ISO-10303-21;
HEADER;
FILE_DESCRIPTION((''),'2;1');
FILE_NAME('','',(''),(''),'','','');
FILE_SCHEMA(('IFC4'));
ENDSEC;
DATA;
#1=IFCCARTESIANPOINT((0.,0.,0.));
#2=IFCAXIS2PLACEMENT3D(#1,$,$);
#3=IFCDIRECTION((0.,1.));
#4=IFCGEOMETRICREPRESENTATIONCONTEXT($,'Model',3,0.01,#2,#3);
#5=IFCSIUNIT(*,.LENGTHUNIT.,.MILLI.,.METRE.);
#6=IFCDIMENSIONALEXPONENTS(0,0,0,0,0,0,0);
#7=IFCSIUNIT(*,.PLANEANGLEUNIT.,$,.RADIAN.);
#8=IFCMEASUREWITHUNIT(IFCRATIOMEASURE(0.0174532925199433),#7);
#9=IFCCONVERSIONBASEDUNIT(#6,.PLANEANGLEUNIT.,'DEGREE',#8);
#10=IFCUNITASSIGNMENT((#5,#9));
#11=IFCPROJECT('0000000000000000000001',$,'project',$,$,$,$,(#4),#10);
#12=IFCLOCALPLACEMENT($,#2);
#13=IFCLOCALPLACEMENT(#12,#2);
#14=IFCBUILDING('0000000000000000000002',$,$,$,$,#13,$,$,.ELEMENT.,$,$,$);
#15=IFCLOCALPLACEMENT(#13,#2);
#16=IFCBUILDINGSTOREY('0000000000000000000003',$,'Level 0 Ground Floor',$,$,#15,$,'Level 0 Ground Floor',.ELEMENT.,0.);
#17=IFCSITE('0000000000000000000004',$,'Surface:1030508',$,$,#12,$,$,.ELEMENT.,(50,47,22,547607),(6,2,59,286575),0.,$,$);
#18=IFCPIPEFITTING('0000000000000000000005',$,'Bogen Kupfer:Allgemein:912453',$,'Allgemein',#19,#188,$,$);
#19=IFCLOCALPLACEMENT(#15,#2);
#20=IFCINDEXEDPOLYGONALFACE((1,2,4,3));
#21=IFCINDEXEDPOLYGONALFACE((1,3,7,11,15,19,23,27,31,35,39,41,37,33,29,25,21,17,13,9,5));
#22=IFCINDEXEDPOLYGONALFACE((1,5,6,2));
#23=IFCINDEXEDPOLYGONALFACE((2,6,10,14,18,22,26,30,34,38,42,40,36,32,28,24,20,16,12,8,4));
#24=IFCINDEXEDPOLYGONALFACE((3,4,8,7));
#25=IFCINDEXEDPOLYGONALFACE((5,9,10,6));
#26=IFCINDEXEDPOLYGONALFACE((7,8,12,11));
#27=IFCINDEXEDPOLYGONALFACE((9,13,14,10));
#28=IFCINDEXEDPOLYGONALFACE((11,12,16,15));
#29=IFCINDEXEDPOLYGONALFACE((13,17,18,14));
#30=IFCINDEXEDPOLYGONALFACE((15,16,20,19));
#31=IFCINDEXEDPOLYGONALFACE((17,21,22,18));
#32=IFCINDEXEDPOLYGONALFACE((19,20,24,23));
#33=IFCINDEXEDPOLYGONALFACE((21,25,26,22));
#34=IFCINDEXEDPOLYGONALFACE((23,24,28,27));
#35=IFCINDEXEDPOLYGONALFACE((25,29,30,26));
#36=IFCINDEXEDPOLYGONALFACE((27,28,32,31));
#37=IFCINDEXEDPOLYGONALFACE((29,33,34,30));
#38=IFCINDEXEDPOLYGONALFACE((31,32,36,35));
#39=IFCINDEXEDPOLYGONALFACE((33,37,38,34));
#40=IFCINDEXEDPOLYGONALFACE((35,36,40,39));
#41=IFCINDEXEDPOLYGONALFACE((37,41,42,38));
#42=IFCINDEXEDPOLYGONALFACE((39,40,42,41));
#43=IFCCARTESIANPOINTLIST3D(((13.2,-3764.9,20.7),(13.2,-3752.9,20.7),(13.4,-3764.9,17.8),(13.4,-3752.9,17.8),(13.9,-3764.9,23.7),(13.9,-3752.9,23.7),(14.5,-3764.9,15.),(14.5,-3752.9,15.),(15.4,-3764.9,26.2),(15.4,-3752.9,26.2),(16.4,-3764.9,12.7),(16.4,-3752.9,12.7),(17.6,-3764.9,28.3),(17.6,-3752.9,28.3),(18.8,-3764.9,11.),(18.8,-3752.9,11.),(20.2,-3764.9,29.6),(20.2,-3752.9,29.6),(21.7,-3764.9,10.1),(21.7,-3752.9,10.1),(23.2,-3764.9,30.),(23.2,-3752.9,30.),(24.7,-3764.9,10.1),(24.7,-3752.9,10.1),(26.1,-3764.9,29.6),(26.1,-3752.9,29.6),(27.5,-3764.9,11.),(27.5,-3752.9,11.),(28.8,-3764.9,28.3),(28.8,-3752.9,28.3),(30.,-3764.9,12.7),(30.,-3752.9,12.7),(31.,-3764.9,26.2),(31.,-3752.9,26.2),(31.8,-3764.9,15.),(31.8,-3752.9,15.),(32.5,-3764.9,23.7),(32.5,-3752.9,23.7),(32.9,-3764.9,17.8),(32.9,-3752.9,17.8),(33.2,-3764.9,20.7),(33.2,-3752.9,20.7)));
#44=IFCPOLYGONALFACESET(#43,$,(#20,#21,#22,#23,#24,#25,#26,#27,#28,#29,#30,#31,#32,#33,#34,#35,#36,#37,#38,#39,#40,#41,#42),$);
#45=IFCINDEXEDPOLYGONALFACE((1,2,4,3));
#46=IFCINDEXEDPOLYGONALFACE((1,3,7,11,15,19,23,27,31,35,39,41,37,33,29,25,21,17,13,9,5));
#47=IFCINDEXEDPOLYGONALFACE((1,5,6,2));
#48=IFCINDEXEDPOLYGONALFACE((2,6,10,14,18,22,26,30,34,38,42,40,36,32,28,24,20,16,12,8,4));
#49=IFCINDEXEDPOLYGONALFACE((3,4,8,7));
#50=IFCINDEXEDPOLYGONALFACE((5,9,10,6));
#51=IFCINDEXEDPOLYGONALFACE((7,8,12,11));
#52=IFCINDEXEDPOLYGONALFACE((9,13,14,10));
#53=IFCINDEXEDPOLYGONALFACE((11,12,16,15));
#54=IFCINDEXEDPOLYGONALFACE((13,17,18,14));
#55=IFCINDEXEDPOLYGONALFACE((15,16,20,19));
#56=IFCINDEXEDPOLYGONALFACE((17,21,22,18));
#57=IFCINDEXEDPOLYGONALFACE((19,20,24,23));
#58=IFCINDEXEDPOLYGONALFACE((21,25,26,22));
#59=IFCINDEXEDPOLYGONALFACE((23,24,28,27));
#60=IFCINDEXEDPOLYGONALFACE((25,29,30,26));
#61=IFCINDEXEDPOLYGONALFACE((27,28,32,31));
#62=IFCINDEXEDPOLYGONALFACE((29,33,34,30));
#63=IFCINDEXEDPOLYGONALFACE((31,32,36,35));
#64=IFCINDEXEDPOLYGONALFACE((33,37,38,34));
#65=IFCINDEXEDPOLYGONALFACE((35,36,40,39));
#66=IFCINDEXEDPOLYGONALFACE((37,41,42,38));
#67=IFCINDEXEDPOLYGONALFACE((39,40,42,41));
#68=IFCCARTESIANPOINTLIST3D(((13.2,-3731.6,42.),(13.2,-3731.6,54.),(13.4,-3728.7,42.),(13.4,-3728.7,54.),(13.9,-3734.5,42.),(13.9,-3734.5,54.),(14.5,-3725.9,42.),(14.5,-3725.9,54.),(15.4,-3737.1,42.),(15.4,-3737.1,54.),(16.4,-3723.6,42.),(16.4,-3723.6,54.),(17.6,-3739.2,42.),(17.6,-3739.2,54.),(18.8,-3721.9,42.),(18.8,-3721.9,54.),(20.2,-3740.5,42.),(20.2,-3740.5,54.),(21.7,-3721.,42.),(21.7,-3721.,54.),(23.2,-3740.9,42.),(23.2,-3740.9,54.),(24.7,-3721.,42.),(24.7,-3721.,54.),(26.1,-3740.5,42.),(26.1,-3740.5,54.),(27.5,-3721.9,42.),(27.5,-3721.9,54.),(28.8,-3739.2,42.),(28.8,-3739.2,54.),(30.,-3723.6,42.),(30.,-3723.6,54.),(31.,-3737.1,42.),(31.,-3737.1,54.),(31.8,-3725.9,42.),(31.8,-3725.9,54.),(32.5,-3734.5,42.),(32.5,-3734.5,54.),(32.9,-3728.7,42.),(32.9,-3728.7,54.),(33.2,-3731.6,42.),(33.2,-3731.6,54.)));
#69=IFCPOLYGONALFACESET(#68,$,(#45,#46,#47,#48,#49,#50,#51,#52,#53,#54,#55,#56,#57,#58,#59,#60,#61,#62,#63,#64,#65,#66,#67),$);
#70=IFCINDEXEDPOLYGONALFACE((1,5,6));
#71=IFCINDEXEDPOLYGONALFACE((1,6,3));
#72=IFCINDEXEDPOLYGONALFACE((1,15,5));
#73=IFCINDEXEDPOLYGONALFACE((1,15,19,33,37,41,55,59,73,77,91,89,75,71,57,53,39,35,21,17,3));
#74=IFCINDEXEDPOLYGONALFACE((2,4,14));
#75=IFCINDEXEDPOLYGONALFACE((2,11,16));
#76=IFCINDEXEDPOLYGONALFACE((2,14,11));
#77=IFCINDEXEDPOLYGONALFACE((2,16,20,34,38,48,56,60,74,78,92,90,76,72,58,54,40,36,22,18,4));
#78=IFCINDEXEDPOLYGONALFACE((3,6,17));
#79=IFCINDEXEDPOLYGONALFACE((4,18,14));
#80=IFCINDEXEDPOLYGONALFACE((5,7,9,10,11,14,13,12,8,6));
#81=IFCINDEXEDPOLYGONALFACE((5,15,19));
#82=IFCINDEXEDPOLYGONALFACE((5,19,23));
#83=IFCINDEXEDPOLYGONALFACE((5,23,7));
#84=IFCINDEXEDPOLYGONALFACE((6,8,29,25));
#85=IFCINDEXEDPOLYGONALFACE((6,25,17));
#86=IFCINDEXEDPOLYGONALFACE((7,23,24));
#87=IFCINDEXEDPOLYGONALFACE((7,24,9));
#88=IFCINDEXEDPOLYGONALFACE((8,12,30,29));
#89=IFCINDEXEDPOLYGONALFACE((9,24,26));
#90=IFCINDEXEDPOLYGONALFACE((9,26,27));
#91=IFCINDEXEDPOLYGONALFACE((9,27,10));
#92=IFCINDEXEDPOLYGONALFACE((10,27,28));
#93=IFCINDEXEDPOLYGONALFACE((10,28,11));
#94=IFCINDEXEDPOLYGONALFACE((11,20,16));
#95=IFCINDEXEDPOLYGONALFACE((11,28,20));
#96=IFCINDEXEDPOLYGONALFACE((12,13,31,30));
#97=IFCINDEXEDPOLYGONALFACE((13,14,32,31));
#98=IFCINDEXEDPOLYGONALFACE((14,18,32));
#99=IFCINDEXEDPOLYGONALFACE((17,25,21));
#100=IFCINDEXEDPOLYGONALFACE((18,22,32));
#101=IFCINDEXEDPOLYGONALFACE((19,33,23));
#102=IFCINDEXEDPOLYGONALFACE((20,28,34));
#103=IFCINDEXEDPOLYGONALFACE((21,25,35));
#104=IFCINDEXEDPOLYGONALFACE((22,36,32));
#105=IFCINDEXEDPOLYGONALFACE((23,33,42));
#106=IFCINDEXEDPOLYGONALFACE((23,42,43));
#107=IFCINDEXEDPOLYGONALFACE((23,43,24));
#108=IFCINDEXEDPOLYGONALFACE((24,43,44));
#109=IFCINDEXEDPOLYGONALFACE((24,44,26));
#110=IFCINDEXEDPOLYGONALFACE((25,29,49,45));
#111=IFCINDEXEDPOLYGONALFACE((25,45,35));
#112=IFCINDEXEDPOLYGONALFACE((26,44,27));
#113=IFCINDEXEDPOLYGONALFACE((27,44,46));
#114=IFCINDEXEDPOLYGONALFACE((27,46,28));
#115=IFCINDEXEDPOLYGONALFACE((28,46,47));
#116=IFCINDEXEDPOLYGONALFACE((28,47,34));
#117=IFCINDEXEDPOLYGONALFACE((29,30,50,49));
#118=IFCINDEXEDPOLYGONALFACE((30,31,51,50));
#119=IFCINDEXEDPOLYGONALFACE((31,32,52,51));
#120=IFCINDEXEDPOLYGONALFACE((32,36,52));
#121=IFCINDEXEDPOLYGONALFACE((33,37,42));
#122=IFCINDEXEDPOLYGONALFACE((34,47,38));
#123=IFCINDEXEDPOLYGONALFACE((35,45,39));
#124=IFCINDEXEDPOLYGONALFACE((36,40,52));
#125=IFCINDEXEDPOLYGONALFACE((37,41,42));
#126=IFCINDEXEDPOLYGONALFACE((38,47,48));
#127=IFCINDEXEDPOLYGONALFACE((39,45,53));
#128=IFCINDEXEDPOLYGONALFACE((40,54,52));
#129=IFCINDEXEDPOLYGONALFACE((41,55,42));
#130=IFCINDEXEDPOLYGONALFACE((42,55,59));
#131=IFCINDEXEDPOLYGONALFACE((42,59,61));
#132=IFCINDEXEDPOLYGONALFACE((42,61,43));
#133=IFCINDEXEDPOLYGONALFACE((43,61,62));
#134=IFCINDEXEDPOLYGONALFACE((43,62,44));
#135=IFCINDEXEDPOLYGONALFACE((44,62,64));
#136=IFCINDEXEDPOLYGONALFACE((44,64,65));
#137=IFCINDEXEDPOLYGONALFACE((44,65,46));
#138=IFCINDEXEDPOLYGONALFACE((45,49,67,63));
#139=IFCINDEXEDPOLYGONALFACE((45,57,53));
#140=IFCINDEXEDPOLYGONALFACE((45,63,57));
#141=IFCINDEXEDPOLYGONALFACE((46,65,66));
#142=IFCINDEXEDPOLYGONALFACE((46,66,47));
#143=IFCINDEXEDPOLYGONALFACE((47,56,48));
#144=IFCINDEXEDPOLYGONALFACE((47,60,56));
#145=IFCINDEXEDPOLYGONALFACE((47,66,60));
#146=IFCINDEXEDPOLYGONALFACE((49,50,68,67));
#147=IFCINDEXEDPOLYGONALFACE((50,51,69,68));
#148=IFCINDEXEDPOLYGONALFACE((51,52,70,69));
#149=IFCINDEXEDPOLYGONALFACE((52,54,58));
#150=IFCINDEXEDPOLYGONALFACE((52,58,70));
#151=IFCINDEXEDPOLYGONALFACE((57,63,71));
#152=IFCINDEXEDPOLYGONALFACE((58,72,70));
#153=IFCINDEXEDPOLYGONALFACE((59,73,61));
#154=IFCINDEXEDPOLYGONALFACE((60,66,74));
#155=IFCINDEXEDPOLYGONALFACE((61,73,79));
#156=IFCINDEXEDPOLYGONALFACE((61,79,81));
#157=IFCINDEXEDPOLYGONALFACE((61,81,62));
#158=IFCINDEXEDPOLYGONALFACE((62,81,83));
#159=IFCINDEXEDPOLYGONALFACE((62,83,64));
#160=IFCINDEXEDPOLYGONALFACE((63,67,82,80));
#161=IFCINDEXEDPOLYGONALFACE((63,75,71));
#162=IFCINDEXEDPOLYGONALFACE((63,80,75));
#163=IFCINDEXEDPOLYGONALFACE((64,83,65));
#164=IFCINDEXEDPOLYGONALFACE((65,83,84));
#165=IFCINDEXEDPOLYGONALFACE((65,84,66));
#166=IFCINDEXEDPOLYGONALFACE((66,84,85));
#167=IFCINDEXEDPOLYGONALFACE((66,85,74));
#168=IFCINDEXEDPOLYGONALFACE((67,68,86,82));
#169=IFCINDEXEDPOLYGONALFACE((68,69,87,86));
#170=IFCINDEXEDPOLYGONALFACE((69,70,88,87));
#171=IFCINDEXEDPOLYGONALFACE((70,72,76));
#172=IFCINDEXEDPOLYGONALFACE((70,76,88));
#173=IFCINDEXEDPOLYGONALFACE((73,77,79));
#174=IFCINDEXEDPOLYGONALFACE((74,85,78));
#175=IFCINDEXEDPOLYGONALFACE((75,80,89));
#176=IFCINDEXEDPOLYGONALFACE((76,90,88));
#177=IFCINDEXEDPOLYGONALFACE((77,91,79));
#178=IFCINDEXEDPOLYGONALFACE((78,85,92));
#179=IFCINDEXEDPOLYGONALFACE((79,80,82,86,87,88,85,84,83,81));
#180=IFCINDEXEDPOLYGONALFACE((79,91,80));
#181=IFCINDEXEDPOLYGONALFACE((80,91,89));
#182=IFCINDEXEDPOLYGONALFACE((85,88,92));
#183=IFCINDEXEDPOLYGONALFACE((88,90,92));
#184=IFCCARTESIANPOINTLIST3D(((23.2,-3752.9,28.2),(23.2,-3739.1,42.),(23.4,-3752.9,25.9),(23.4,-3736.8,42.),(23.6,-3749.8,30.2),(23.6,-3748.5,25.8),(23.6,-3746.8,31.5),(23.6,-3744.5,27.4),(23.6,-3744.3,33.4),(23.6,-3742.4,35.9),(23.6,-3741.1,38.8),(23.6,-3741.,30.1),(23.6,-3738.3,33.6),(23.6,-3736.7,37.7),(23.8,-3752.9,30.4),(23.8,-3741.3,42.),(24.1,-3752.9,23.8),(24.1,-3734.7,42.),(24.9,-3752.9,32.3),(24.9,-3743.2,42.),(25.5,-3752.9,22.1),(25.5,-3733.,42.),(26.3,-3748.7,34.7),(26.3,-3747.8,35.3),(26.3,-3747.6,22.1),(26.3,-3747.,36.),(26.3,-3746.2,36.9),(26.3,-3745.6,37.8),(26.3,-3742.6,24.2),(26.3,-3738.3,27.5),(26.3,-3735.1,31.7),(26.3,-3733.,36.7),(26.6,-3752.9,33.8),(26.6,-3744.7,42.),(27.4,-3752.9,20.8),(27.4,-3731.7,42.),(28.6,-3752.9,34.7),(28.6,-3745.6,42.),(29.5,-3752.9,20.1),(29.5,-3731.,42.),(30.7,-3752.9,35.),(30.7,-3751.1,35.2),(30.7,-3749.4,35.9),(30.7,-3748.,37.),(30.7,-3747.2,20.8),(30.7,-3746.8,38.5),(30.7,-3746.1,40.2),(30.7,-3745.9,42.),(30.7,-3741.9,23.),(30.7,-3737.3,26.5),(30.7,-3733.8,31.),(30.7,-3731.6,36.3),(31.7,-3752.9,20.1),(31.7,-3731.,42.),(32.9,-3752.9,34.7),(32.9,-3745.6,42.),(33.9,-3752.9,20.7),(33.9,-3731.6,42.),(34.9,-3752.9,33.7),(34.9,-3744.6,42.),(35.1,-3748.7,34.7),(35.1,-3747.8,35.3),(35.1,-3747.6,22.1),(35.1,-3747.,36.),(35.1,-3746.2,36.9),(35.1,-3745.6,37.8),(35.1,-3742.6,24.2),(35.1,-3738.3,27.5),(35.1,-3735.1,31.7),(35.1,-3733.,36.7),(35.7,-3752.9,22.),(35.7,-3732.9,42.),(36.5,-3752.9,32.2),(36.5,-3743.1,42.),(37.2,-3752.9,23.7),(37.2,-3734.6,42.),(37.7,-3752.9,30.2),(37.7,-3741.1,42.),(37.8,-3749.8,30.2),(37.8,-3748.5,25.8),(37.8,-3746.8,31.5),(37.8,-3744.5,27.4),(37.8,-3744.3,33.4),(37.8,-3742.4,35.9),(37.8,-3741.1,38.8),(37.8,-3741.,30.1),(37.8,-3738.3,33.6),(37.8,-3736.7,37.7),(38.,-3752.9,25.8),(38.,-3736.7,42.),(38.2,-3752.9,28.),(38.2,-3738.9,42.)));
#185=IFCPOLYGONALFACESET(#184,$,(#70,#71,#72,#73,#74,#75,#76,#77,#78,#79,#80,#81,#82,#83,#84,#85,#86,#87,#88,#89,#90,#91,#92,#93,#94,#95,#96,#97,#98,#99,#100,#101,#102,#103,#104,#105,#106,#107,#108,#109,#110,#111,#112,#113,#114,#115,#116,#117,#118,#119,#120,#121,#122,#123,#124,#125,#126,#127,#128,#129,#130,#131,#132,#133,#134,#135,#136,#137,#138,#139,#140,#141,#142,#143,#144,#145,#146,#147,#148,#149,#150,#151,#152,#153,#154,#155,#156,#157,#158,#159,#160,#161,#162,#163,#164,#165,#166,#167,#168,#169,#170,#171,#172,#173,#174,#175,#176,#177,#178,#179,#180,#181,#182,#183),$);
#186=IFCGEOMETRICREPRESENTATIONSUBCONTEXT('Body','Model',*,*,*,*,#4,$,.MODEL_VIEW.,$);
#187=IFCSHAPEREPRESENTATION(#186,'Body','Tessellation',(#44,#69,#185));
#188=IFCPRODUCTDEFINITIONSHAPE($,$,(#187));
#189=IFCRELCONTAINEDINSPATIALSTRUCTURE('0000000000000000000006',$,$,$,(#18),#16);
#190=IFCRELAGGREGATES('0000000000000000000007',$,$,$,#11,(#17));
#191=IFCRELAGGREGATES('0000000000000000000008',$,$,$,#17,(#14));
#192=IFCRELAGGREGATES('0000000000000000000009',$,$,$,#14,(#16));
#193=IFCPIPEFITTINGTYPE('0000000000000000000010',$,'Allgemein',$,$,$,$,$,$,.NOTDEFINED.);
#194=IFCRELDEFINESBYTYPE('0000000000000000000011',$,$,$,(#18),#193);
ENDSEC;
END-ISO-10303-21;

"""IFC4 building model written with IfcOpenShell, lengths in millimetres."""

from ifc_helpers import new_model, entity, si_unit, converted_unit, direction, frame, frame_2d, origin, place, context, subcontext, project, spatial, circle, extrude, source, transform, mapped, type_object, type_shapes, element, save


model = new_model("IFC4")

# Units and contexts
model_context = context("Model", 3, precision=0.01, world=origin(), true_north=direction((0.0, 1.0)))
body_context = subcontext(model_context, "Body", "Model", "MODEL_VIEW")
ifc_project = project(units=[si_unit("LENGTHUNIT", "METRE", prefix="MILLI"), converted_unit("PLANEANGLEUNIT", "DEGREE", entity("IfcRatioMeasure", 0.0174532925199433), si_unit("PLANEANGLEUNIT", "RADIAN"), dimensions=[0, 0, 0, 0, 0, 0, 0])], contexts=[model_context])

# Site, building, storey
site_placement = place(None, origin())
site = spatial("IfcSite", under=ifc_project, at=site_placement, Name="Surface:1030508", CompositionType="ELEMENT", RefLatitude=(50, 47, 22, 547607), RefLongitude=(6, 2, 59, 286575), RefElevation=0.0)
building_placement = place(site_placement, origin())
building = spatial("IfcBuilding", under=site, at=building_placement, CompositionType="ELEMENT")
storey_placement = place(building_placement, origin())
storey = spatial("IfcBuildingStorey", under=building, at=storey_placement, Name="Level 0 Ground Floor", LongName="Level 0 Ground Floor", CompositionType="ELEMENT", Elevation=0.0)

# Shared definitions
pipe_fitting_type_1 = type_object("IfcPipeFittingType", Name="Allgemein", PredefinedType="NOTDEFINED")
ifc_direction_1 = entity("IfcDirection", [0.0, 0.0, -1.0])
trimmed_curve_1 = entity("IfcTrimmedCurve", entity("IfcCircle", entity("IfcAxis2Placement2D", entity("IfcCartesianPoint", [-14.5, 0.0]), entity("IfcDirection", [0.0, 1.0])), 14.5), [entity("IfcParameterValue", 270.0)], [entity("IfcParameterValue", 0.0)], True, "PARAMETER")
shared_shape_1 = source(origin(), body_context, "Body", "SolidModel", [
    extrude(circle(Radius=10.0, at=frame_2d((0.0, 0.0), x_axis=(1.0, 0.0))), frame((0.0, 22.0, 0.0), z_axis=(0.0, 1.0, 0.0), x_axis=(-1.0, 0.0, 0.0)), (0.0, 0.0, 1.0), 12.0),
    extrude(circle(Radius=10.0, at=frame_2d((0.0, 0.0), x_axis=(1.0, 0.0))), frame((-34.0, 0.0, 0.0), z_axis=(1.0, 0.0, 0.0), x_axis=(0.0, 1.0, 0.0)), (0.0, 0.0, 1.0), 12.0),
    entity("IfcSurfaceCurveSweptAreaSolid", entity("IfcCircleProfileDef", "AREA", None, entity("IfcAxis2Placement2D", entity("IfcCartesianPoint", [0.0, 7.5]), entity("IfcDirection", [1.0, 0.0])), 7.5), entity("IfcAxis2Placement3D", entity("IfcCartesianPoint", [-7.5, 22.0, 0.0]), ifc_direction_1, entity("IfcDirection", [1.0, 0.0, 0.0])), trimmed_curve_1, 0.0, 90.0, entity("IfcSurfaceOfLinearExtrusion", entity("IfcArbitraryOpenProfileDef", "CURVE", None, trimmed_curve_1), entity("IfcAxis2Placement3D", entity("IfcCartesianPoint", [0.0, 0.0, -304.8])), ifc_direction_1, 1.0)),
])
type_shapes(pipe_fitting_type_1, [shared_shape_1])

# Pipe fitting
pipe_fitting_1_placement = place(storey_placement, frame((23.2, -3730.9, 20.0), z_axis=(-1.0, 0.0, 0.0), x_axis=(0.0, 0.0, -1.0)))
element("IfcPipeFitting", 1, at=pipe_fitting_1_placement, inside=storey, type_object=pipe_fitting_type_1, Name="Bogen Kupfer:Allgemein:912453", ObjectType="Allgemein", context=body_context, shape_type="MappedRepresentation", body=[
    mapped(shared_shape_1, transform((0.0, 0.0, 0.0), scale=1.0)),
])

save(model, "model.ifc")
